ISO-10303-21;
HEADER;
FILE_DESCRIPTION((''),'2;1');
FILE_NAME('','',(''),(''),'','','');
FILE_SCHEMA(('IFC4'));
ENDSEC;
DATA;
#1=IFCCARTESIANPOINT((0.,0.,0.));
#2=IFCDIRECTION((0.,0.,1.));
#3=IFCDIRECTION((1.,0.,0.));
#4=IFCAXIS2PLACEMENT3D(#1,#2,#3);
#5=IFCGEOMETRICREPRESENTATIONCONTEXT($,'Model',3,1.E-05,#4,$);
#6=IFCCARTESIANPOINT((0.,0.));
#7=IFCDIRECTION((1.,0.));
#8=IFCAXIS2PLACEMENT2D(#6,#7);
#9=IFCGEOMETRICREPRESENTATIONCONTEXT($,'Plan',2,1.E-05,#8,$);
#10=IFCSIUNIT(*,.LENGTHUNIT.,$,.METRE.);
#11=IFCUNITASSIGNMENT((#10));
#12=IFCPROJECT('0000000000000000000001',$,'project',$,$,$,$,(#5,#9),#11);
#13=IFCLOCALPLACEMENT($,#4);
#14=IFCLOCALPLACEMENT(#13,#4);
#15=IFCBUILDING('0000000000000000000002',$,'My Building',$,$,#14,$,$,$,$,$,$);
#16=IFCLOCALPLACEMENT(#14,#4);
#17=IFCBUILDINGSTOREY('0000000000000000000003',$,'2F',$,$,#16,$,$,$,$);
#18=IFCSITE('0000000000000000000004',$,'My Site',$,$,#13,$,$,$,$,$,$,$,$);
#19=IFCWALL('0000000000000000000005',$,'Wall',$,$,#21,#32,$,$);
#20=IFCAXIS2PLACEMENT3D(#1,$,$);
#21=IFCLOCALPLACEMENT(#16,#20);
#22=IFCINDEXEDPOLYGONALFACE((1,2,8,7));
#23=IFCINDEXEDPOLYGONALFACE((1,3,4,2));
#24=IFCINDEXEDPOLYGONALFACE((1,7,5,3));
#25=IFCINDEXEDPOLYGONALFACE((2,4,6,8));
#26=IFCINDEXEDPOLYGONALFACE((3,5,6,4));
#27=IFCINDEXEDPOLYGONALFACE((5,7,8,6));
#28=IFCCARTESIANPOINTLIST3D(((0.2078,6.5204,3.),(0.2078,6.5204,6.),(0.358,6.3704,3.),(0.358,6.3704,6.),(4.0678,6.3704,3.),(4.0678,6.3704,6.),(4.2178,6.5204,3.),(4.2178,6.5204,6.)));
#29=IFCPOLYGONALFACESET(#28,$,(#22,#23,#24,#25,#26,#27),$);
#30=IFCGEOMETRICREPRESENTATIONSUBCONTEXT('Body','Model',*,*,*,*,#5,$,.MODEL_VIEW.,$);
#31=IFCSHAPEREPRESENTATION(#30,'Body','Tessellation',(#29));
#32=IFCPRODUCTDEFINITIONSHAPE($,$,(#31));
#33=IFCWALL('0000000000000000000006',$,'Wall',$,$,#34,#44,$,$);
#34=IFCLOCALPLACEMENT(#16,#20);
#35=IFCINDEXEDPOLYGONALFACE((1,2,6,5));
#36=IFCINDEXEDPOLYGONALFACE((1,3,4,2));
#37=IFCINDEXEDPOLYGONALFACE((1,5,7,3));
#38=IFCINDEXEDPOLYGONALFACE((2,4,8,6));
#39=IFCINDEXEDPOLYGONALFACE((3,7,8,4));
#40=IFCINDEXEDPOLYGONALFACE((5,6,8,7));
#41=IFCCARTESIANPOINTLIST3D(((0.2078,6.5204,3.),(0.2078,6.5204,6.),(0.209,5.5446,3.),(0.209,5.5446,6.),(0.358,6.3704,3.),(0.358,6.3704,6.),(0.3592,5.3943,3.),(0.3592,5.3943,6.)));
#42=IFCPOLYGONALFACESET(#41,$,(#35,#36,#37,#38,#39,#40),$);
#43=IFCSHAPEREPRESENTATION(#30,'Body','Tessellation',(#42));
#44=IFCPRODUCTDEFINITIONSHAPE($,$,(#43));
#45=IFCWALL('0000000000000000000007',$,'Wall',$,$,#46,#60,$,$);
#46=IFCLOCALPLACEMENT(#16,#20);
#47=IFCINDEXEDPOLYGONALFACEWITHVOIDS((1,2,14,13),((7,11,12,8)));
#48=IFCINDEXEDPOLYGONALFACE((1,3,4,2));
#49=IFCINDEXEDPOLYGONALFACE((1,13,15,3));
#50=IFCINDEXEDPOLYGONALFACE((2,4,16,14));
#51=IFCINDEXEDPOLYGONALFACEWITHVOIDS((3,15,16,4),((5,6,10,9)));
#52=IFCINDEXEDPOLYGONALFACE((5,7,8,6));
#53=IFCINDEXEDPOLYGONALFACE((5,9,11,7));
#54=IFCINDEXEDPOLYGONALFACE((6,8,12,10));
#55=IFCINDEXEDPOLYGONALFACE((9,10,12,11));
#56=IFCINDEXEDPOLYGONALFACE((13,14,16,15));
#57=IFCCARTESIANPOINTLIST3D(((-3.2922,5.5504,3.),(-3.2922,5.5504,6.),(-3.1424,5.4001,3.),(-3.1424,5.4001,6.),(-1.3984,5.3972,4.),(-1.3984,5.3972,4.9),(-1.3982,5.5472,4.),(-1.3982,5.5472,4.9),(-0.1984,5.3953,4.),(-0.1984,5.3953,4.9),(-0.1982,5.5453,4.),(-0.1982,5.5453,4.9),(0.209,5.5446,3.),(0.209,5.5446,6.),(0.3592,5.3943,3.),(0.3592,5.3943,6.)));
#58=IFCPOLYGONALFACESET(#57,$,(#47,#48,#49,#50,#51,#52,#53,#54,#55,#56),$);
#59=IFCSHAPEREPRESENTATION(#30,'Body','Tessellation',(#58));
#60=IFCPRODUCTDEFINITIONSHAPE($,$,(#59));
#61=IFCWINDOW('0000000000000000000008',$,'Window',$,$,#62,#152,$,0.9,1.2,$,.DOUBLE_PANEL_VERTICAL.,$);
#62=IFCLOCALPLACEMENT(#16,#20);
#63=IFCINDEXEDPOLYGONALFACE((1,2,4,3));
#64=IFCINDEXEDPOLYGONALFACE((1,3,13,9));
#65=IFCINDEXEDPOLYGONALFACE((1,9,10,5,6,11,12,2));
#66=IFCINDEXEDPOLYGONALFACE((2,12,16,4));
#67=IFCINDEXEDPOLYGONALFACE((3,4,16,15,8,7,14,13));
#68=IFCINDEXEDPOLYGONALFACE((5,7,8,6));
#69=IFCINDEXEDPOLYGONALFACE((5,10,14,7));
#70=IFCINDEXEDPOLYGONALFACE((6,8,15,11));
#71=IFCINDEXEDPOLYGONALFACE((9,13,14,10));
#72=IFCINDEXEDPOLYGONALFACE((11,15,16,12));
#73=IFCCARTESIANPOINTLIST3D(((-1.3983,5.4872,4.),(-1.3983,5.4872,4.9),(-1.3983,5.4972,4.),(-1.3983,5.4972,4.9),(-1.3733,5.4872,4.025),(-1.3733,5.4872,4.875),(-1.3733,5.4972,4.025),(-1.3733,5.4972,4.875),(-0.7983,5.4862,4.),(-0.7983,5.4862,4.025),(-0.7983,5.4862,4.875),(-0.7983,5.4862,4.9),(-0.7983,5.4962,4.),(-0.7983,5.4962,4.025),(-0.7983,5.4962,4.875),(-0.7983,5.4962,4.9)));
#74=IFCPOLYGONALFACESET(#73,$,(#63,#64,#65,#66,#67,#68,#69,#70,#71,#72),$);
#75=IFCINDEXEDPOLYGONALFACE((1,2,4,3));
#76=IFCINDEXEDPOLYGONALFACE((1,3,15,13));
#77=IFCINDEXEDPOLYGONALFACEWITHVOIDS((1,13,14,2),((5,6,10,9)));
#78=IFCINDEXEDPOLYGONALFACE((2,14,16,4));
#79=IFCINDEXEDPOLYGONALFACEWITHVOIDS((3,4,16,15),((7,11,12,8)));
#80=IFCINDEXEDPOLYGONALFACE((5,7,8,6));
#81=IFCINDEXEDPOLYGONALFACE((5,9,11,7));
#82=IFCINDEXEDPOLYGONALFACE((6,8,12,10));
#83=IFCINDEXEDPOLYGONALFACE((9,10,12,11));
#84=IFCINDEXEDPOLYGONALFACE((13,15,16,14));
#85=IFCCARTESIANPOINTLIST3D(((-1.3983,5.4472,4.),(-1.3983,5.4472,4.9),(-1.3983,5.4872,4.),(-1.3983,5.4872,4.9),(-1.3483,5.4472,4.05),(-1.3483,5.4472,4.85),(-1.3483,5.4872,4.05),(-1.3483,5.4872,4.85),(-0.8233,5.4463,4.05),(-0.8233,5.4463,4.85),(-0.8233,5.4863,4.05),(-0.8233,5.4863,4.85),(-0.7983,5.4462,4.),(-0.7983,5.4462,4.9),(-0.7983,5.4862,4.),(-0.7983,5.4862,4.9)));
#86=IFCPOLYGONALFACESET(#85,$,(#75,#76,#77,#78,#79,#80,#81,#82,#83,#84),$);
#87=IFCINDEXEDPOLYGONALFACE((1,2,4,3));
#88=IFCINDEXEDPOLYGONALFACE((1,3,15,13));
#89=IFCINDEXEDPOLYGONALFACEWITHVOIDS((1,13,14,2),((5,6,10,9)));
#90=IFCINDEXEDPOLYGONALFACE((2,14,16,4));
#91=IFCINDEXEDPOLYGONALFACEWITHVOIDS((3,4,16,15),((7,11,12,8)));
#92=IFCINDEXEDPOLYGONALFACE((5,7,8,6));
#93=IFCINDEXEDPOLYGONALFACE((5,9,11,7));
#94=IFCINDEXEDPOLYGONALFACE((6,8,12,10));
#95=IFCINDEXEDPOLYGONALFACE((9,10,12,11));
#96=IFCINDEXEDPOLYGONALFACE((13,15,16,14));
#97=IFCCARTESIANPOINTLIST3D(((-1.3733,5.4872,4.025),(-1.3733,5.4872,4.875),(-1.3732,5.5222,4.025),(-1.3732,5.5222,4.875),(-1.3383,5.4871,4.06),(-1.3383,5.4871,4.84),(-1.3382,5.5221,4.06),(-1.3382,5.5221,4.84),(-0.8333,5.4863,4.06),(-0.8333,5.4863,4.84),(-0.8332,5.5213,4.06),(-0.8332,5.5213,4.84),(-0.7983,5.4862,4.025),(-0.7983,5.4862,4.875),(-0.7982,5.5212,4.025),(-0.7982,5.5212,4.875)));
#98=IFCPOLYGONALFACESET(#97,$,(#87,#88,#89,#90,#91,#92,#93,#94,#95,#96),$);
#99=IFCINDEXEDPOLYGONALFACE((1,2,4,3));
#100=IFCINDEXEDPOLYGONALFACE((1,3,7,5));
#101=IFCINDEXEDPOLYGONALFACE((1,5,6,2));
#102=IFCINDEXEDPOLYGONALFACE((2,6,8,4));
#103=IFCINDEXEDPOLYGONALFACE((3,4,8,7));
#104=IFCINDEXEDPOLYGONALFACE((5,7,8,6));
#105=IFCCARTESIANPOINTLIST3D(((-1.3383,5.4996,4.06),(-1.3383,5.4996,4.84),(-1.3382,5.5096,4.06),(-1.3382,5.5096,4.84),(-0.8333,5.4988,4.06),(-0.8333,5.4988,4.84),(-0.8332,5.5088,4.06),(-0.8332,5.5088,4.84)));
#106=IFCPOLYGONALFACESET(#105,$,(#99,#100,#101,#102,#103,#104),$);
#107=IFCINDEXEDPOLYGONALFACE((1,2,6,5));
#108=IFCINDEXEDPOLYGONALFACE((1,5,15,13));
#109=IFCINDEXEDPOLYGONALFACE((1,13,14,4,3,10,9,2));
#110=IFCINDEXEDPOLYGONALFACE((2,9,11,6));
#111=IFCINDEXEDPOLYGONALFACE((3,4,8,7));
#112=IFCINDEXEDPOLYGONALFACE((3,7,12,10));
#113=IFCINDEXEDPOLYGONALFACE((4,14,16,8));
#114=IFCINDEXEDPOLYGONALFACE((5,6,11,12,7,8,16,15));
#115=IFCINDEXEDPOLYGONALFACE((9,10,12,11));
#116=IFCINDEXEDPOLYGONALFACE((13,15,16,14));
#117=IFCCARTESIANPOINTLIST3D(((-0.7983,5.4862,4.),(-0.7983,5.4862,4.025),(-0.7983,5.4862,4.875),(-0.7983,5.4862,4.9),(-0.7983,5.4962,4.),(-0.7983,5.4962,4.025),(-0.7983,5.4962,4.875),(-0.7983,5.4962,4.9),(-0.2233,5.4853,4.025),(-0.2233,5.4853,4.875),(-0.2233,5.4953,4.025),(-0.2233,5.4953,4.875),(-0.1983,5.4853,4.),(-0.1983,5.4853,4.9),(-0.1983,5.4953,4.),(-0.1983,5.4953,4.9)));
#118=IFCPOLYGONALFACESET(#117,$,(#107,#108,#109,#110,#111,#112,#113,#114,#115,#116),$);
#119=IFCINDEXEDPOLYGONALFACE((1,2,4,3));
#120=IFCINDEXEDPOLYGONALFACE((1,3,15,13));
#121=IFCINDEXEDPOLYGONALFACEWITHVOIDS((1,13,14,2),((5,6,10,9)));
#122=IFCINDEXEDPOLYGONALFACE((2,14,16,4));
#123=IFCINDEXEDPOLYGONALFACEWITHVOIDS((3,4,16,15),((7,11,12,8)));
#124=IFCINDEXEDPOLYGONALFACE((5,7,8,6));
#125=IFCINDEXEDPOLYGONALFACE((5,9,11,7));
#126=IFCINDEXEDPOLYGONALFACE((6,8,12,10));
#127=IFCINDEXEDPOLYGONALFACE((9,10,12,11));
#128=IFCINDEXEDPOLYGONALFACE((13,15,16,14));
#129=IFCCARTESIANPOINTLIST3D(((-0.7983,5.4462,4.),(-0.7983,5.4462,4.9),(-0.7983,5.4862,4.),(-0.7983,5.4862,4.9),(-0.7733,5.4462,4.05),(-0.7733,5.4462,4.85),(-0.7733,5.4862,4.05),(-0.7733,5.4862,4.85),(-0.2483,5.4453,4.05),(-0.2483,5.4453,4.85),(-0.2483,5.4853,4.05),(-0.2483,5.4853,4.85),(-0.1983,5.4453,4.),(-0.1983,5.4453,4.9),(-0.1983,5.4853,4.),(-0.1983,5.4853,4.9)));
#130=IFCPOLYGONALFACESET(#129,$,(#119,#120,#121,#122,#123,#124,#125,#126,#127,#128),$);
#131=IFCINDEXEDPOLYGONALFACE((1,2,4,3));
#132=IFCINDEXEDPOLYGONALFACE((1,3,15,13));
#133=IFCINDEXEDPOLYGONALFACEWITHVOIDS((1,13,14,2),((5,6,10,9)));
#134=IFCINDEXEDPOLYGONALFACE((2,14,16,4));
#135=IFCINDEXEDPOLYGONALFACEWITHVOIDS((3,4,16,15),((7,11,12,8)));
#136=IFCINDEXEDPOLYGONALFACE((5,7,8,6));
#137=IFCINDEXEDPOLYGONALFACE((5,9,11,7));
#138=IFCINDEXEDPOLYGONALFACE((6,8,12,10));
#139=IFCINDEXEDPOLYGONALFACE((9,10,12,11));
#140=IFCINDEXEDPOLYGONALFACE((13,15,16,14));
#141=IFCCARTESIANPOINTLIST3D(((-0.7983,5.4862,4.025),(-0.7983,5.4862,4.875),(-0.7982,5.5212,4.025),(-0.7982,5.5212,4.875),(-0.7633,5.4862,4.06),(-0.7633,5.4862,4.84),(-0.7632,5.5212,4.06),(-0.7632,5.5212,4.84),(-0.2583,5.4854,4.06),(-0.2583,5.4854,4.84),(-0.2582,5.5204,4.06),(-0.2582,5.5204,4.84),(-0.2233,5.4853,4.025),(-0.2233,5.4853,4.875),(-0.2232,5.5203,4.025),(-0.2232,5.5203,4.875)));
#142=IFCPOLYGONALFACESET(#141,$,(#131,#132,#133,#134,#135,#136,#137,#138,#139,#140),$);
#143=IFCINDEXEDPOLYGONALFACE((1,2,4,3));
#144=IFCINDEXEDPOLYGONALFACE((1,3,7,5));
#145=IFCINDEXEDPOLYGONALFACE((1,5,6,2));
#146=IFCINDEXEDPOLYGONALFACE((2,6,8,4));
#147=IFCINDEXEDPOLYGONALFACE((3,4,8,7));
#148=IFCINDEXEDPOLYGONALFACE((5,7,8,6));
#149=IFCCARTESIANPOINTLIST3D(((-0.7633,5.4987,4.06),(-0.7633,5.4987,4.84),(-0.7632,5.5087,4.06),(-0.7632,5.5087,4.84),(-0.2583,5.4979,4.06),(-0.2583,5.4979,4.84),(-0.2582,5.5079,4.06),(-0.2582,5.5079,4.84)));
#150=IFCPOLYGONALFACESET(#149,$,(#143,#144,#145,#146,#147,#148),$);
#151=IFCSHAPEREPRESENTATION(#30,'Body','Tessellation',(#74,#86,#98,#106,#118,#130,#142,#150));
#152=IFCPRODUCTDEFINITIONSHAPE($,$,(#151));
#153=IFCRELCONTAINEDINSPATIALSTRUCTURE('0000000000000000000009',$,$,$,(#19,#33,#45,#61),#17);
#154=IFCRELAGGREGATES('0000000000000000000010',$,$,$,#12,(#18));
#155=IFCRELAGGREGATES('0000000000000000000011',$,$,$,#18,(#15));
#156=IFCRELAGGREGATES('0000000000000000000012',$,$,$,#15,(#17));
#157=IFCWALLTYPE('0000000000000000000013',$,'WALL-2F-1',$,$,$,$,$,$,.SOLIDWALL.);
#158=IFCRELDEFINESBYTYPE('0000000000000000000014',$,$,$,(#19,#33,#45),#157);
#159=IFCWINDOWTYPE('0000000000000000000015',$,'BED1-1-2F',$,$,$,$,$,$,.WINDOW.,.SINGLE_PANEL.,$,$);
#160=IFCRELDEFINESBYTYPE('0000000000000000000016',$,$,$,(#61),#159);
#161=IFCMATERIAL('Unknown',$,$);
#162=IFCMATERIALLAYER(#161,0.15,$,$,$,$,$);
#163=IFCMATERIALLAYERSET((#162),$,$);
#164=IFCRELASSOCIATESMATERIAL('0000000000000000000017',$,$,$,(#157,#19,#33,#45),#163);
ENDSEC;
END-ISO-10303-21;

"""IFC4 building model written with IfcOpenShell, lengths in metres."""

from ifc_helpers import new_model, entity, si_unit, frame, origin_with_axes, origin_2d_with_axis, place, context, subcontext, project, spatial, line, indexed_curve, outline, extrude, shape, source, transform, mapped, material, layer, layer_set, layer_usage, type_object, type_shapes, element, fill, save


model = new_model("IFC4")

# Units and contexts
model_context = context("Model", 3, precision=1e-05, world=origin_with_axes())
plan_context = context("Plan", 2, precision=1e-05, world=origin_2d_with_axis())
body_context_1 = subcontext(model_context, "Body", "Model", "MODEL_VIEW")
body_context_2 = subcontext(plan_context, "Body", "Plan", "PLAN_VIEW")
ifc_project = project(units=[si_unit("LENGTHUNIT", "METRE")], contexts=[model_context, plan_context])

# Site, building, storey
site_placement = place(None, origin_with_axes())
site = spatial("IfcSite", under=ifc_project, at=site_placement, Name="My Site")
building_placement = place(site_placement, origin_with_axes())
building = spatial("IfcBuilding", under=site, at=building_placement, Name="My Building")
storey_placement = place(building_placement, origin_with_axes())
storey = spatial("IfcBuildingStorey", under=building, at=storey_placement, Name="2F")

# Shared definitions
ifc_material = material(Name="Unknown")

# Shared definitions
ifc_layer_1 = layer(ifc_material, 0.15)
ifc_layer_set_1 = layer_set([ifc_layer_1])
wall_type_1 = type_object("IfcWallType", Name="WALL-2F-1", PredefinedType="SOLIDWALL", material=ifc_layer_set_1)

# Walls
ifc_layer_usage_1 = layer_usage(ifc_layer_set_1, "AXIS2", "POSITIVE", 0.0)
wall_1_placement = place(storey_placement, frame((4.2178, 6.5204, 3.0), z_axis=(0.0, 0.0, 1.0), x_axis=(-1.0, 0.0, 0.0)))
element("IfcWall", 1, at=wall_1_placement, inside=storey, type_object=wall_type_1, material=ifc_layer_usage_1, Name="Wall", context=body_context_1, shape_type="SweptSolid", body=[
    extrude(outline(indexed_curve([(0.0, 0.0), (0.15, 0.15), (3.8598, 0.15), (4.01, 0.0)], segments=[line(1, 2, 3, 4, 1)])), origin_with_axes(), (0.0, 0.0, 1.0), 3.0),
])
ifc_layer_usage_2 = layer_usage(ifc_layer_set_1, "AXIS2", "POSITIVE", 0.0)
wall_2_placement = place(storey_placement, frame((0.2078, 6.5204, 3.0), z_axis=(0.0, 0.0, 1.0), x_axis=(0.001246, -0.999999, 0.0)))
element("IfcWall", 2, at=wall_2_placement, inside=storey, type_object=wall_type_1, material=ifc_layer_usage_2, Name="Wall", context=body_context_1, shape_type="SweptSolid", body=[
    extrude(outline(indexed_curve([(0.0, 0.0), (0.1502, 0.15), (1.1263, 0.15), (0.9758, 0.0)], segments=[line(1, 2, 3, 4, 1)])), origin_with_axes(), (0.0, 0.0, 1.0), 3.0),
])

# Wall, opening, window
ifc_layer_usage_3 = layer_usage(ifc_layer_set_1, "AXIS2", "POSITIVE", 0.0)
wall_3_placement = place(storey_placement, frame((0.209, 5.5446, 3.0), z_axis=(0.0, 0.0, 1.0), x_axis=(-0.999999, 0.001662, 0.0)))
wall_3 = element("IfcWall", 3, at=wall_3_placement, inside=storey, type_object=wall_type_1, material=ifc_layer_usage_3, Name="Wall", context=body_context_1, shape_type="SweptSolid", body=[
    extrude(outline(indexed_curve([(0.0, 0.0), (-0.1504, 0.15), (3.3512, 0.15), (3.5012, 0.0)], segments=[line(1, 2, 3, 4, 1)])), origin_with_axes(), (0.0, 0.0, 1.0), 3.0),
])
shared_shape_1 = source(origin_with_axes(), body_context_1, "Body", "SweptSolid", [
    extrude(outline(indexed_curve([(0.0, 0.0), (1.2, 0.0), (1.2, 0.9), (0.0, 0.9)], segments=[line(1, 2, 3, 4, 1)])), frame((0.0, -0.6, 0.0), z_axis=(0.0, -1.0, 0.0), x_axis=(1.0, 0.0, 0.0)), (0.0, 0.0, -1.0), 1.2),
])
opening_1_placement = place(wall_3_placement, frame((1.6072, 0.15, 1.0), z_axis=(0.0, 0.0, 1.0), x_axis=(-1.0, 0.0, 0.0)))
opening_1 = element("IfcOpeningElement", 4, at=opening_1_placement, cuts=wall_3, PredefinedType="OPENING", context=body_context_1, shape_type="MappedRepresentation", body=[
    mapped(shared_shape_1, transform((0.0, 0.0, 0.0), x_axis=(1.0, 0.0, 0.0), y_axis=(0.0, 1.0, 0.0), z_axis=(0.0, 0.0, 1.0), scale=1.0)),
])
window_type_1 = type_object("IfcWindowType", Name="BED1-1-2F", PartitioningType="SINGLE_PANEL", PredefinedType="WINDOW")
shared_shape_2 = source(origin_with_axes(), body_context_1, "Body", "SweptSolid", [
    extrude(outline(indexed_curve([(0.6, 0.0), (0.0, 0.0), (0.0, 0.9), (0.6, 0.9), (0.6, 0.875), (0.025, 0.875), (0.025, 0.025), (0.6, 0.025)], segments=[line(1, 2, 3, 4, 5, 6, 7, 8, 1)])), frame((0.0, 0.09, 0.0), z_axis=(0.0, -1.0, 0.0), x_axis=(1.0, 0.0, 0.0)), (0.0, 0.0, -1.0), 0.01),
    extrude(outline(indexed_curve([(0.0, 0.0), (0.6, 0.0), (0.6, 0.9), (0.0, 0.9)], segments=[line(1, 2, 3, 4, 1)]), holes=[indexed_curve([(0.05, 0.05), (0.575, 0.05), (0.575, 0.85), (0.05, 0.85)], segments=[line(1, 2, 3, 4, 1)])]), frame((0.0, 0.05, 0.0), z_axis=(0.0, -1.0, 0.0), x_axis=(1.0, 0.0, 0.0)), (0.0, 0.0, -1.0), 0.04),
    extrude(outline(indexed_curve([(0.0, 0.0), (0.575, 0.0), (0.575, 0.85), (0.0, 0.85)], segments=[line(1, 2, 3, 4, 1)]), holes=[indexed_curve([(0.035, 0.035), (0.54, 0.035), (0.54, 0.815), (0.035, 0.815)], segments=[line(1, 2, 3, 4, 1)])]), frame((0.025, 0.09, 0.025), z_axis=(0.0, -1.0, 0.0), x_axis=(1.0, 0.0, 0.0)), (0.0, 0.0, -1.0), 0.035),
    extrude(outline(indexed_curve([(0.035, 0.035), (0.54, 0.035), (0.54, 0.815), (0.035, 0.815)], segments=[line(1, 2, 3, 4, 1)])), frame((0.025, 0.1025, 0.025), z_axis=(0.0, -1.0, 0.0), x_axis=(1.0, 0.0, 0.0)), (0.0, 0.0, -1.0), 0.01),
    extrude(outline(indexed_curve([(0.0, 0.9), (0.6, 0.9), (0.6, 0.0), (0.0, 0.0), (0.0, 0.025), (0.575, 0.025), (0.575, 0.875), (0.0, 0.875)], segments=[line(1, 2, 3, 4, 5, 6, 7, 8, 1)])), frame((0.6, 0.09, 0.0), z_axis=(0.0, -1.0, 0.0), x_axis=(1.0, 0.0, 0.0)), (0.0, 0.0, -1.0), 0.01),
    extrude(outline(indexed_curve([(0.0, 0.0), (0.6, 0.0), (0.6, 0.9), (0.0, 0.9)], segments=[line(1, 2, 3, 4, 1)]), holes=[indexed_curve([(0.025, 0.05), (0.55, 0.05), (0.55, 0.85), (0.025, 0.85)], segments=[line(1, 2, 3, 4, 1)])]), frame((0.6, 0.05, 0.0), z_axis=(0.0, -1.0, 0.0), x_axis=(1.0, 0.0, 0.0)), (0.0, 0.0, -1.0), 0.04),
    extrude(outline(indexed_curve([(0.0, 0.0), (0.575, 0.0), (0.575, 0.85), (0.0, 0.85)], segments=[line(1, 2, 3, 4, 1)]), holes=[indexed_curve([(0.035, 0.035), (0.54, 0.035), (0.54, 0.815), (0.035, 0.815)], segments=[line(1, 2, 3, 4, 1)])]), frame((0.6, 0.09, 0.025), z_axis=(0.0, -1.0, 0.0), x_axis=(1.0, 0.0, 0.0)), (0.0, 0.0, -1.0), 0.035),
    extrude(outline(indexed_curve([(0.035, 0.035), (0.54, 0.035), (0.54, 0.815), (0.035, 0.815)], segments=[line(1, 2, 3, 4, 1)])), frame((0.6, 0.1025, 0.025), z_axis=(0.0, -1.0, 0.0), x_axis=(1.0, 0.0, 0.0)), (0.0, 0.0, -1.0), 0.01),
])
shared_shape_3 = source(origin_with_axes(), body_context_2, "Body", "Curve2D", [
    entity("IfcIndexedPolyCurve", entity("IfcCartesianPointList2D", [[0.05, 0.05], [0.575, 0.05]])),
    entity("IfcIndexedPolyCurve", entity("IfcCartesianPointList2D", [[0.0, 0.1], [0.025, 0.1], [0.025, 0.09], [0.05, 0.09], [0.05, 0.05], [0.0, 0.05]]), [entity("IfcLineIndex", [1, 2, 3, 4, 5, 6, 1])]),
    entity("IfcIndexedPolyCurve", entity("IfcCartesianPointList2D", [[0.6, 0.1], [0.6, 0.1], [0.6, 0.09], [0.575, 0.09], [0.575, 0.05], [0.6, 0.05]])),
    entity("IfcIndexedPolyCurve", entity("IfcCartesianPointList2D", [[0.025, 0.09], [0.06, 0.09], [0.06, 0.125], [0.025, 0.125]]), [entity("IfcLineIndex", [1, 2, 3, 4, 1])]),
    entity("IfcIndexedPolyCurve", entity("IfcCartesianPointList2D", [[0.6, 0.09], [0.565, 0.09], [0.565, 0.125], [0.6, 0.125]]), [entity("IfcLineIndex", [1, 2, 3, 4, 1])]),
    entity("IfcIndexedPolyCurve", entity("IfcCartesianPointList2D", [[0.06, 0.09], [0.565, 0.09]])),
    entity("IfcIndexedPolyCurve", entity("IfcCartesianPointList2D", [[0.06, 0.125], [0.565, 0.125]])),
    entity("IfcIndexedPolyCurve", entity("IfcCartesianPointList2D", [[0.06, 0.1075], [0.565, 0.1075]])),
    entity("IfcIndexedPolyCurve", entity("IfcCartesianPointList2D", [[0.625, 0.05], [1.15, 0.05]])),
    entity("IfcIndexedPolyCurve", entity("IfcCartesianPointList2D", [[0.6, 0.1], [0.6, 0.1], [0.6, 0.09], [0.625, 0.09], [0.625, 0.05], [0.6, 0.05]])),
    entity("IfcIndexedPolyCurve", entity("IfcCartesianPointList2D", [[1.2, 0.1], [1.175, 0.1], [1.175, 0.09], [1.15, 0.09], [1.15, 0.05], [1.2, 0.05]]), [entity("IfcLineIndex", [1, 2, 3, 4, 5, 6, 1])]),
    entity("IfcIndexedPolyCurve", entity("IfcCartesianPointList2D", [[0.6, 0.09], [0.635, 0.09], [0.635, 0.125], [0.6, 0.125]]), [entity("IfcLineIndex", [1, 2, 3, 4, 1])]),
    entity("IfcIndexedPolyCurve", entity("IfcCartesianPointList2D", [[1.175, 0.09], [1.14, 0.09], [1.14, 0.125], [1.175, 0.125]]), [entity("IfcLineIndex", [1, 2, 3, 4, 1])]),
    entity("IfcIndexedPolyCurve", entity("IfcCartesianPointList2D", [[0.635, 0.09], [1.14, 0.09]])),
    entity("IfcIndexedPolyCurve", entity("IfcCartesianPointList2D", [[0.635, 0.125], [1.14, 0.125]])),
    entity("IfcIndexedPolyCurve", entity("IfcCartesianPointList2D", [[0.635, 0.1075], [1.14, 0.1075]])),
])
type_shapes(window_type_1, [shared_shape_2, shared_shape_3])
window_1_placement = place(opening_1_placement, frame((0.0, 0.0, 0.0), z_axis=(0.0, 0.0, 1.0), x_axis=(1.0, 0.0, 0.0)))
window_1 = element("IfcWindow", 5, at=window_1_placement, inside=storey, type_object=window_type_1, Name="Window", OverallHeight=0.9, OverallWidth=1.2, PartitioningType="DOUBLE_PANEL_VERTICAL", shapes=[
    shape(body_context_1, "Body", "MappedRepresentation", [mapped(shared_shape_2, transform((0.0, 0.0, 0.0), x_axis=(1.0, 0.0, 0.0), y_axis=(0.0, 1.0, 0.0), z_axis=(0.0, 0.0, 1.0), scale=1.0))]),
    shape(body_context_2, "Body", "MappedRepresentation", [mapped(shared_shape_3, transform((0.0, 0.0, 0.0), x_axis=(1.0, 0.0, 0.0), y_axis=(0.0, 1.0, 0.0), z_axis=(0.0, 0.0, 1.0), scale=1.0))]),
])
fill(opening_1, window_1)

save(model, "model.ifc")
